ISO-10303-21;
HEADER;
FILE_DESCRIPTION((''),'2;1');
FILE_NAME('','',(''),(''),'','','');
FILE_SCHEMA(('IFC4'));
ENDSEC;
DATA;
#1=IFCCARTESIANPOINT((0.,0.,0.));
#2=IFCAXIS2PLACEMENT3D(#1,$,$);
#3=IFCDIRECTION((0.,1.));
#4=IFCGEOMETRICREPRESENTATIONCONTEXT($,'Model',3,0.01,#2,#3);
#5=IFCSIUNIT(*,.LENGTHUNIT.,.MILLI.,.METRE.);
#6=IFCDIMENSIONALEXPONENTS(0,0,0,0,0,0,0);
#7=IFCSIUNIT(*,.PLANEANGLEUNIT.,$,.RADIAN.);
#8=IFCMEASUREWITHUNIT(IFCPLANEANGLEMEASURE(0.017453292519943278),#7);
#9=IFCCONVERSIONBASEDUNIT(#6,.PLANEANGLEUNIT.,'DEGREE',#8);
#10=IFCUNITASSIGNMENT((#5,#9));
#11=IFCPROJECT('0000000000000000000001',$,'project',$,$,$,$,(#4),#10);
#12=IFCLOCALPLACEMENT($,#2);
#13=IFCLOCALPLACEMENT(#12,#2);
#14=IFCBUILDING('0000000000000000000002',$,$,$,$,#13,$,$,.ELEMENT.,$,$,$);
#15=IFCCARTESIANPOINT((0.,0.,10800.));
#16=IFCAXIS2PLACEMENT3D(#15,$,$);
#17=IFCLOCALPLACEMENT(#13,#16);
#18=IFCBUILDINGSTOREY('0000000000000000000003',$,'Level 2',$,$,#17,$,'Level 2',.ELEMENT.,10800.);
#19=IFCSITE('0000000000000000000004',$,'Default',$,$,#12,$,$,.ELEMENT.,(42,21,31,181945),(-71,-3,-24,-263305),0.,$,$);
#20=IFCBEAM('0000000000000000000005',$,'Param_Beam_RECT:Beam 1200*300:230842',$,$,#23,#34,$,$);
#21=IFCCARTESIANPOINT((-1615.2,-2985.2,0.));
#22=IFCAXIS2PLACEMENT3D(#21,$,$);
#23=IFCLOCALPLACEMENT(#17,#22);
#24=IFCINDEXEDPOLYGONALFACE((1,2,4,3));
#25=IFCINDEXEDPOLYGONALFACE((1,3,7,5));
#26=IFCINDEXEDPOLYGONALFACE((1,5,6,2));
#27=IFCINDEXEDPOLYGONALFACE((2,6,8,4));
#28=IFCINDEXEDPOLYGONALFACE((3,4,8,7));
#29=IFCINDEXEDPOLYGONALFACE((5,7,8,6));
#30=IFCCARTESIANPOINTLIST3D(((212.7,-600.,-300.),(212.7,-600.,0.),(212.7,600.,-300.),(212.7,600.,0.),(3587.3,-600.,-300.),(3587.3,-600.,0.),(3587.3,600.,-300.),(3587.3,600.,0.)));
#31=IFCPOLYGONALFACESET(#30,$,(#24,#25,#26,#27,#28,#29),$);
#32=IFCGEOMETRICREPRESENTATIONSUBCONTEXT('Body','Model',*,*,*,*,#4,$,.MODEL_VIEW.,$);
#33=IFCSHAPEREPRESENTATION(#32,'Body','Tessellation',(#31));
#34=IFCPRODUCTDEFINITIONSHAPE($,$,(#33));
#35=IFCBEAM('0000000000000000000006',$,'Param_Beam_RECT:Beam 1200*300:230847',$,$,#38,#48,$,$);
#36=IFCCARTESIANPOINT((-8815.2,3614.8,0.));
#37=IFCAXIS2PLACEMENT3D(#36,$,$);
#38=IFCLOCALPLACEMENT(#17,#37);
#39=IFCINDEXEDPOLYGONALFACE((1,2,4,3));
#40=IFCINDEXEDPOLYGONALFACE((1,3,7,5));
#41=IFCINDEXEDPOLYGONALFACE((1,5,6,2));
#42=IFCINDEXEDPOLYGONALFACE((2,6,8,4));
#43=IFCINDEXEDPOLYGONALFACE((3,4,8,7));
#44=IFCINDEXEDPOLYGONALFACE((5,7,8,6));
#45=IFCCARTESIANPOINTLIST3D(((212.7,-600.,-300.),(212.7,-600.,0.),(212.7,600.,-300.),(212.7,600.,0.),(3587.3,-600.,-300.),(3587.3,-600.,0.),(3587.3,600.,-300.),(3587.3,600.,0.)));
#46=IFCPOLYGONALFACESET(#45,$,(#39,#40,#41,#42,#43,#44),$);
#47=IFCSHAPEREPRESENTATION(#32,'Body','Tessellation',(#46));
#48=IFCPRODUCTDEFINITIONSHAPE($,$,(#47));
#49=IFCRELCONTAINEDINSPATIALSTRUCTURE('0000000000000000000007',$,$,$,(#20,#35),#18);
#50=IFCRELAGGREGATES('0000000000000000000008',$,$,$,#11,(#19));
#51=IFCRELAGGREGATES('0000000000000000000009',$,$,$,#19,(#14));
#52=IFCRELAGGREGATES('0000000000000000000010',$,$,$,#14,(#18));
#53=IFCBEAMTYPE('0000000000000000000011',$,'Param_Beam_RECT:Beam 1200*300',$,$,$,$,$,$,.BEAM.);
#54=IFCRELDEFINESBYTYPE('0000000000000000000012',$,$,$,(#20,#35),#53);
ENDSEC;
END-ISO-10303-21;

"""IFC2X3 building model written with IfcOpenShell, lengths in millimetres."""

from ifc_helpers import new_model, entity, si_unit, converted_unit, direction, frame, frame_2d, origin, place, context, subcontext, project, spatial, rectangle, extrude, type_object, element, save


model = new_model("IFC2X3")

# Units and contexts
model_context = context("Model", 3, precision=0.01, world=origin(), true_north=direction((0.0, 1.0)))
body_context = subcontext(model_context, "Body", "Model", "MODEL_VIEW")
ifc_project = project(units=[si_unit("LENGTHUNIT", "METRE", prefix="MILLI"), converted_unit("PLANEANGLEUNIT", "DEGREE", entity("IfcPlaneAngleMeasure", 0.017453292519943278), si_unit("PLANEANGLEUNIT", "RADIAN"), dimensions=[0, 0, 0, 0, 0, 0, 0])], contexts=[model_context])

# Site, building, storey
site_placement = place(None, origin())
site = spatial("IfcSite", under=ifc_project, at=site_placement, Name="Default", CompositionType="ELEMENT", RefLatitude=(42, 21, 31, 181945), RefLongitude=(-71, -3, -24, -263305), RefElevation=0.0)
building_placement = place(site_placement, origin())
building = spatial("IfcBuilding", under=site, at=building_placement, CompositionType="ELEMENT")
storey_placement = place(building_placement, frame((0.0, 0.0, 10800.0)))
storey = spatial("IfcBuildingStorey", under=building, at=storey_placement, Name="Level 2", LongName="Level 2", CompositionType="ELEMENT", Elevation=10800.0)

# Beams
beam_type_1 = type_object("IfcBeamType", Name="Param_Beam_RECT:Beam 1200*300", PredefinedType="BEAM")
beam_1_placement = place(storey_placement, frame((-1615.2, -2985.2, 0.0)))
element("IfcBeam", 1, at=beam_1_placement, inside=storey, type_object=beam_type_1, Name="Param_Beam_RECT:Beam 1200*300:230842", context=body_context, shape_type="SweptSolid", body=[
    extrude(rectangle(XDim=300.0, YDim=1200.0, at=frame_2d((0.0, 0.0), x_axis=(1.0, 0.0))), frame((212.7, 0.0, -150.0), z_axis=(1.0, 0.0, 0.0), x_axis=(0.0, 0.0, -1.0)), (0.0, 0.0, 1.0), 3374.6),
])
beam_2_placement = place(storey_placement, frame((-8815.2, 3614.8, 0.0)))
element("IfcBeam", 2, at=beam_2_placement, inside=storey, type_object=beam_type_1, Name="Param_Beam_RECT:Beam 1200*300:230847", context=body_context, shape_type="SweptSolid", body=[
    extrude(rectangle(XDim=300.0, YDim=1200.0, at=frame_2d((0.0, 0.0), x_axis=(1.0, 0.0))), frame((212.7, 0.0, -150.0), z_axis=(1.0, 0.0, 0.0), x_axis=(0.0, 0.0, -1.0)), (0.0, 0.0, 1.0), 3374.6),
])

save(model, "model.ifc")
